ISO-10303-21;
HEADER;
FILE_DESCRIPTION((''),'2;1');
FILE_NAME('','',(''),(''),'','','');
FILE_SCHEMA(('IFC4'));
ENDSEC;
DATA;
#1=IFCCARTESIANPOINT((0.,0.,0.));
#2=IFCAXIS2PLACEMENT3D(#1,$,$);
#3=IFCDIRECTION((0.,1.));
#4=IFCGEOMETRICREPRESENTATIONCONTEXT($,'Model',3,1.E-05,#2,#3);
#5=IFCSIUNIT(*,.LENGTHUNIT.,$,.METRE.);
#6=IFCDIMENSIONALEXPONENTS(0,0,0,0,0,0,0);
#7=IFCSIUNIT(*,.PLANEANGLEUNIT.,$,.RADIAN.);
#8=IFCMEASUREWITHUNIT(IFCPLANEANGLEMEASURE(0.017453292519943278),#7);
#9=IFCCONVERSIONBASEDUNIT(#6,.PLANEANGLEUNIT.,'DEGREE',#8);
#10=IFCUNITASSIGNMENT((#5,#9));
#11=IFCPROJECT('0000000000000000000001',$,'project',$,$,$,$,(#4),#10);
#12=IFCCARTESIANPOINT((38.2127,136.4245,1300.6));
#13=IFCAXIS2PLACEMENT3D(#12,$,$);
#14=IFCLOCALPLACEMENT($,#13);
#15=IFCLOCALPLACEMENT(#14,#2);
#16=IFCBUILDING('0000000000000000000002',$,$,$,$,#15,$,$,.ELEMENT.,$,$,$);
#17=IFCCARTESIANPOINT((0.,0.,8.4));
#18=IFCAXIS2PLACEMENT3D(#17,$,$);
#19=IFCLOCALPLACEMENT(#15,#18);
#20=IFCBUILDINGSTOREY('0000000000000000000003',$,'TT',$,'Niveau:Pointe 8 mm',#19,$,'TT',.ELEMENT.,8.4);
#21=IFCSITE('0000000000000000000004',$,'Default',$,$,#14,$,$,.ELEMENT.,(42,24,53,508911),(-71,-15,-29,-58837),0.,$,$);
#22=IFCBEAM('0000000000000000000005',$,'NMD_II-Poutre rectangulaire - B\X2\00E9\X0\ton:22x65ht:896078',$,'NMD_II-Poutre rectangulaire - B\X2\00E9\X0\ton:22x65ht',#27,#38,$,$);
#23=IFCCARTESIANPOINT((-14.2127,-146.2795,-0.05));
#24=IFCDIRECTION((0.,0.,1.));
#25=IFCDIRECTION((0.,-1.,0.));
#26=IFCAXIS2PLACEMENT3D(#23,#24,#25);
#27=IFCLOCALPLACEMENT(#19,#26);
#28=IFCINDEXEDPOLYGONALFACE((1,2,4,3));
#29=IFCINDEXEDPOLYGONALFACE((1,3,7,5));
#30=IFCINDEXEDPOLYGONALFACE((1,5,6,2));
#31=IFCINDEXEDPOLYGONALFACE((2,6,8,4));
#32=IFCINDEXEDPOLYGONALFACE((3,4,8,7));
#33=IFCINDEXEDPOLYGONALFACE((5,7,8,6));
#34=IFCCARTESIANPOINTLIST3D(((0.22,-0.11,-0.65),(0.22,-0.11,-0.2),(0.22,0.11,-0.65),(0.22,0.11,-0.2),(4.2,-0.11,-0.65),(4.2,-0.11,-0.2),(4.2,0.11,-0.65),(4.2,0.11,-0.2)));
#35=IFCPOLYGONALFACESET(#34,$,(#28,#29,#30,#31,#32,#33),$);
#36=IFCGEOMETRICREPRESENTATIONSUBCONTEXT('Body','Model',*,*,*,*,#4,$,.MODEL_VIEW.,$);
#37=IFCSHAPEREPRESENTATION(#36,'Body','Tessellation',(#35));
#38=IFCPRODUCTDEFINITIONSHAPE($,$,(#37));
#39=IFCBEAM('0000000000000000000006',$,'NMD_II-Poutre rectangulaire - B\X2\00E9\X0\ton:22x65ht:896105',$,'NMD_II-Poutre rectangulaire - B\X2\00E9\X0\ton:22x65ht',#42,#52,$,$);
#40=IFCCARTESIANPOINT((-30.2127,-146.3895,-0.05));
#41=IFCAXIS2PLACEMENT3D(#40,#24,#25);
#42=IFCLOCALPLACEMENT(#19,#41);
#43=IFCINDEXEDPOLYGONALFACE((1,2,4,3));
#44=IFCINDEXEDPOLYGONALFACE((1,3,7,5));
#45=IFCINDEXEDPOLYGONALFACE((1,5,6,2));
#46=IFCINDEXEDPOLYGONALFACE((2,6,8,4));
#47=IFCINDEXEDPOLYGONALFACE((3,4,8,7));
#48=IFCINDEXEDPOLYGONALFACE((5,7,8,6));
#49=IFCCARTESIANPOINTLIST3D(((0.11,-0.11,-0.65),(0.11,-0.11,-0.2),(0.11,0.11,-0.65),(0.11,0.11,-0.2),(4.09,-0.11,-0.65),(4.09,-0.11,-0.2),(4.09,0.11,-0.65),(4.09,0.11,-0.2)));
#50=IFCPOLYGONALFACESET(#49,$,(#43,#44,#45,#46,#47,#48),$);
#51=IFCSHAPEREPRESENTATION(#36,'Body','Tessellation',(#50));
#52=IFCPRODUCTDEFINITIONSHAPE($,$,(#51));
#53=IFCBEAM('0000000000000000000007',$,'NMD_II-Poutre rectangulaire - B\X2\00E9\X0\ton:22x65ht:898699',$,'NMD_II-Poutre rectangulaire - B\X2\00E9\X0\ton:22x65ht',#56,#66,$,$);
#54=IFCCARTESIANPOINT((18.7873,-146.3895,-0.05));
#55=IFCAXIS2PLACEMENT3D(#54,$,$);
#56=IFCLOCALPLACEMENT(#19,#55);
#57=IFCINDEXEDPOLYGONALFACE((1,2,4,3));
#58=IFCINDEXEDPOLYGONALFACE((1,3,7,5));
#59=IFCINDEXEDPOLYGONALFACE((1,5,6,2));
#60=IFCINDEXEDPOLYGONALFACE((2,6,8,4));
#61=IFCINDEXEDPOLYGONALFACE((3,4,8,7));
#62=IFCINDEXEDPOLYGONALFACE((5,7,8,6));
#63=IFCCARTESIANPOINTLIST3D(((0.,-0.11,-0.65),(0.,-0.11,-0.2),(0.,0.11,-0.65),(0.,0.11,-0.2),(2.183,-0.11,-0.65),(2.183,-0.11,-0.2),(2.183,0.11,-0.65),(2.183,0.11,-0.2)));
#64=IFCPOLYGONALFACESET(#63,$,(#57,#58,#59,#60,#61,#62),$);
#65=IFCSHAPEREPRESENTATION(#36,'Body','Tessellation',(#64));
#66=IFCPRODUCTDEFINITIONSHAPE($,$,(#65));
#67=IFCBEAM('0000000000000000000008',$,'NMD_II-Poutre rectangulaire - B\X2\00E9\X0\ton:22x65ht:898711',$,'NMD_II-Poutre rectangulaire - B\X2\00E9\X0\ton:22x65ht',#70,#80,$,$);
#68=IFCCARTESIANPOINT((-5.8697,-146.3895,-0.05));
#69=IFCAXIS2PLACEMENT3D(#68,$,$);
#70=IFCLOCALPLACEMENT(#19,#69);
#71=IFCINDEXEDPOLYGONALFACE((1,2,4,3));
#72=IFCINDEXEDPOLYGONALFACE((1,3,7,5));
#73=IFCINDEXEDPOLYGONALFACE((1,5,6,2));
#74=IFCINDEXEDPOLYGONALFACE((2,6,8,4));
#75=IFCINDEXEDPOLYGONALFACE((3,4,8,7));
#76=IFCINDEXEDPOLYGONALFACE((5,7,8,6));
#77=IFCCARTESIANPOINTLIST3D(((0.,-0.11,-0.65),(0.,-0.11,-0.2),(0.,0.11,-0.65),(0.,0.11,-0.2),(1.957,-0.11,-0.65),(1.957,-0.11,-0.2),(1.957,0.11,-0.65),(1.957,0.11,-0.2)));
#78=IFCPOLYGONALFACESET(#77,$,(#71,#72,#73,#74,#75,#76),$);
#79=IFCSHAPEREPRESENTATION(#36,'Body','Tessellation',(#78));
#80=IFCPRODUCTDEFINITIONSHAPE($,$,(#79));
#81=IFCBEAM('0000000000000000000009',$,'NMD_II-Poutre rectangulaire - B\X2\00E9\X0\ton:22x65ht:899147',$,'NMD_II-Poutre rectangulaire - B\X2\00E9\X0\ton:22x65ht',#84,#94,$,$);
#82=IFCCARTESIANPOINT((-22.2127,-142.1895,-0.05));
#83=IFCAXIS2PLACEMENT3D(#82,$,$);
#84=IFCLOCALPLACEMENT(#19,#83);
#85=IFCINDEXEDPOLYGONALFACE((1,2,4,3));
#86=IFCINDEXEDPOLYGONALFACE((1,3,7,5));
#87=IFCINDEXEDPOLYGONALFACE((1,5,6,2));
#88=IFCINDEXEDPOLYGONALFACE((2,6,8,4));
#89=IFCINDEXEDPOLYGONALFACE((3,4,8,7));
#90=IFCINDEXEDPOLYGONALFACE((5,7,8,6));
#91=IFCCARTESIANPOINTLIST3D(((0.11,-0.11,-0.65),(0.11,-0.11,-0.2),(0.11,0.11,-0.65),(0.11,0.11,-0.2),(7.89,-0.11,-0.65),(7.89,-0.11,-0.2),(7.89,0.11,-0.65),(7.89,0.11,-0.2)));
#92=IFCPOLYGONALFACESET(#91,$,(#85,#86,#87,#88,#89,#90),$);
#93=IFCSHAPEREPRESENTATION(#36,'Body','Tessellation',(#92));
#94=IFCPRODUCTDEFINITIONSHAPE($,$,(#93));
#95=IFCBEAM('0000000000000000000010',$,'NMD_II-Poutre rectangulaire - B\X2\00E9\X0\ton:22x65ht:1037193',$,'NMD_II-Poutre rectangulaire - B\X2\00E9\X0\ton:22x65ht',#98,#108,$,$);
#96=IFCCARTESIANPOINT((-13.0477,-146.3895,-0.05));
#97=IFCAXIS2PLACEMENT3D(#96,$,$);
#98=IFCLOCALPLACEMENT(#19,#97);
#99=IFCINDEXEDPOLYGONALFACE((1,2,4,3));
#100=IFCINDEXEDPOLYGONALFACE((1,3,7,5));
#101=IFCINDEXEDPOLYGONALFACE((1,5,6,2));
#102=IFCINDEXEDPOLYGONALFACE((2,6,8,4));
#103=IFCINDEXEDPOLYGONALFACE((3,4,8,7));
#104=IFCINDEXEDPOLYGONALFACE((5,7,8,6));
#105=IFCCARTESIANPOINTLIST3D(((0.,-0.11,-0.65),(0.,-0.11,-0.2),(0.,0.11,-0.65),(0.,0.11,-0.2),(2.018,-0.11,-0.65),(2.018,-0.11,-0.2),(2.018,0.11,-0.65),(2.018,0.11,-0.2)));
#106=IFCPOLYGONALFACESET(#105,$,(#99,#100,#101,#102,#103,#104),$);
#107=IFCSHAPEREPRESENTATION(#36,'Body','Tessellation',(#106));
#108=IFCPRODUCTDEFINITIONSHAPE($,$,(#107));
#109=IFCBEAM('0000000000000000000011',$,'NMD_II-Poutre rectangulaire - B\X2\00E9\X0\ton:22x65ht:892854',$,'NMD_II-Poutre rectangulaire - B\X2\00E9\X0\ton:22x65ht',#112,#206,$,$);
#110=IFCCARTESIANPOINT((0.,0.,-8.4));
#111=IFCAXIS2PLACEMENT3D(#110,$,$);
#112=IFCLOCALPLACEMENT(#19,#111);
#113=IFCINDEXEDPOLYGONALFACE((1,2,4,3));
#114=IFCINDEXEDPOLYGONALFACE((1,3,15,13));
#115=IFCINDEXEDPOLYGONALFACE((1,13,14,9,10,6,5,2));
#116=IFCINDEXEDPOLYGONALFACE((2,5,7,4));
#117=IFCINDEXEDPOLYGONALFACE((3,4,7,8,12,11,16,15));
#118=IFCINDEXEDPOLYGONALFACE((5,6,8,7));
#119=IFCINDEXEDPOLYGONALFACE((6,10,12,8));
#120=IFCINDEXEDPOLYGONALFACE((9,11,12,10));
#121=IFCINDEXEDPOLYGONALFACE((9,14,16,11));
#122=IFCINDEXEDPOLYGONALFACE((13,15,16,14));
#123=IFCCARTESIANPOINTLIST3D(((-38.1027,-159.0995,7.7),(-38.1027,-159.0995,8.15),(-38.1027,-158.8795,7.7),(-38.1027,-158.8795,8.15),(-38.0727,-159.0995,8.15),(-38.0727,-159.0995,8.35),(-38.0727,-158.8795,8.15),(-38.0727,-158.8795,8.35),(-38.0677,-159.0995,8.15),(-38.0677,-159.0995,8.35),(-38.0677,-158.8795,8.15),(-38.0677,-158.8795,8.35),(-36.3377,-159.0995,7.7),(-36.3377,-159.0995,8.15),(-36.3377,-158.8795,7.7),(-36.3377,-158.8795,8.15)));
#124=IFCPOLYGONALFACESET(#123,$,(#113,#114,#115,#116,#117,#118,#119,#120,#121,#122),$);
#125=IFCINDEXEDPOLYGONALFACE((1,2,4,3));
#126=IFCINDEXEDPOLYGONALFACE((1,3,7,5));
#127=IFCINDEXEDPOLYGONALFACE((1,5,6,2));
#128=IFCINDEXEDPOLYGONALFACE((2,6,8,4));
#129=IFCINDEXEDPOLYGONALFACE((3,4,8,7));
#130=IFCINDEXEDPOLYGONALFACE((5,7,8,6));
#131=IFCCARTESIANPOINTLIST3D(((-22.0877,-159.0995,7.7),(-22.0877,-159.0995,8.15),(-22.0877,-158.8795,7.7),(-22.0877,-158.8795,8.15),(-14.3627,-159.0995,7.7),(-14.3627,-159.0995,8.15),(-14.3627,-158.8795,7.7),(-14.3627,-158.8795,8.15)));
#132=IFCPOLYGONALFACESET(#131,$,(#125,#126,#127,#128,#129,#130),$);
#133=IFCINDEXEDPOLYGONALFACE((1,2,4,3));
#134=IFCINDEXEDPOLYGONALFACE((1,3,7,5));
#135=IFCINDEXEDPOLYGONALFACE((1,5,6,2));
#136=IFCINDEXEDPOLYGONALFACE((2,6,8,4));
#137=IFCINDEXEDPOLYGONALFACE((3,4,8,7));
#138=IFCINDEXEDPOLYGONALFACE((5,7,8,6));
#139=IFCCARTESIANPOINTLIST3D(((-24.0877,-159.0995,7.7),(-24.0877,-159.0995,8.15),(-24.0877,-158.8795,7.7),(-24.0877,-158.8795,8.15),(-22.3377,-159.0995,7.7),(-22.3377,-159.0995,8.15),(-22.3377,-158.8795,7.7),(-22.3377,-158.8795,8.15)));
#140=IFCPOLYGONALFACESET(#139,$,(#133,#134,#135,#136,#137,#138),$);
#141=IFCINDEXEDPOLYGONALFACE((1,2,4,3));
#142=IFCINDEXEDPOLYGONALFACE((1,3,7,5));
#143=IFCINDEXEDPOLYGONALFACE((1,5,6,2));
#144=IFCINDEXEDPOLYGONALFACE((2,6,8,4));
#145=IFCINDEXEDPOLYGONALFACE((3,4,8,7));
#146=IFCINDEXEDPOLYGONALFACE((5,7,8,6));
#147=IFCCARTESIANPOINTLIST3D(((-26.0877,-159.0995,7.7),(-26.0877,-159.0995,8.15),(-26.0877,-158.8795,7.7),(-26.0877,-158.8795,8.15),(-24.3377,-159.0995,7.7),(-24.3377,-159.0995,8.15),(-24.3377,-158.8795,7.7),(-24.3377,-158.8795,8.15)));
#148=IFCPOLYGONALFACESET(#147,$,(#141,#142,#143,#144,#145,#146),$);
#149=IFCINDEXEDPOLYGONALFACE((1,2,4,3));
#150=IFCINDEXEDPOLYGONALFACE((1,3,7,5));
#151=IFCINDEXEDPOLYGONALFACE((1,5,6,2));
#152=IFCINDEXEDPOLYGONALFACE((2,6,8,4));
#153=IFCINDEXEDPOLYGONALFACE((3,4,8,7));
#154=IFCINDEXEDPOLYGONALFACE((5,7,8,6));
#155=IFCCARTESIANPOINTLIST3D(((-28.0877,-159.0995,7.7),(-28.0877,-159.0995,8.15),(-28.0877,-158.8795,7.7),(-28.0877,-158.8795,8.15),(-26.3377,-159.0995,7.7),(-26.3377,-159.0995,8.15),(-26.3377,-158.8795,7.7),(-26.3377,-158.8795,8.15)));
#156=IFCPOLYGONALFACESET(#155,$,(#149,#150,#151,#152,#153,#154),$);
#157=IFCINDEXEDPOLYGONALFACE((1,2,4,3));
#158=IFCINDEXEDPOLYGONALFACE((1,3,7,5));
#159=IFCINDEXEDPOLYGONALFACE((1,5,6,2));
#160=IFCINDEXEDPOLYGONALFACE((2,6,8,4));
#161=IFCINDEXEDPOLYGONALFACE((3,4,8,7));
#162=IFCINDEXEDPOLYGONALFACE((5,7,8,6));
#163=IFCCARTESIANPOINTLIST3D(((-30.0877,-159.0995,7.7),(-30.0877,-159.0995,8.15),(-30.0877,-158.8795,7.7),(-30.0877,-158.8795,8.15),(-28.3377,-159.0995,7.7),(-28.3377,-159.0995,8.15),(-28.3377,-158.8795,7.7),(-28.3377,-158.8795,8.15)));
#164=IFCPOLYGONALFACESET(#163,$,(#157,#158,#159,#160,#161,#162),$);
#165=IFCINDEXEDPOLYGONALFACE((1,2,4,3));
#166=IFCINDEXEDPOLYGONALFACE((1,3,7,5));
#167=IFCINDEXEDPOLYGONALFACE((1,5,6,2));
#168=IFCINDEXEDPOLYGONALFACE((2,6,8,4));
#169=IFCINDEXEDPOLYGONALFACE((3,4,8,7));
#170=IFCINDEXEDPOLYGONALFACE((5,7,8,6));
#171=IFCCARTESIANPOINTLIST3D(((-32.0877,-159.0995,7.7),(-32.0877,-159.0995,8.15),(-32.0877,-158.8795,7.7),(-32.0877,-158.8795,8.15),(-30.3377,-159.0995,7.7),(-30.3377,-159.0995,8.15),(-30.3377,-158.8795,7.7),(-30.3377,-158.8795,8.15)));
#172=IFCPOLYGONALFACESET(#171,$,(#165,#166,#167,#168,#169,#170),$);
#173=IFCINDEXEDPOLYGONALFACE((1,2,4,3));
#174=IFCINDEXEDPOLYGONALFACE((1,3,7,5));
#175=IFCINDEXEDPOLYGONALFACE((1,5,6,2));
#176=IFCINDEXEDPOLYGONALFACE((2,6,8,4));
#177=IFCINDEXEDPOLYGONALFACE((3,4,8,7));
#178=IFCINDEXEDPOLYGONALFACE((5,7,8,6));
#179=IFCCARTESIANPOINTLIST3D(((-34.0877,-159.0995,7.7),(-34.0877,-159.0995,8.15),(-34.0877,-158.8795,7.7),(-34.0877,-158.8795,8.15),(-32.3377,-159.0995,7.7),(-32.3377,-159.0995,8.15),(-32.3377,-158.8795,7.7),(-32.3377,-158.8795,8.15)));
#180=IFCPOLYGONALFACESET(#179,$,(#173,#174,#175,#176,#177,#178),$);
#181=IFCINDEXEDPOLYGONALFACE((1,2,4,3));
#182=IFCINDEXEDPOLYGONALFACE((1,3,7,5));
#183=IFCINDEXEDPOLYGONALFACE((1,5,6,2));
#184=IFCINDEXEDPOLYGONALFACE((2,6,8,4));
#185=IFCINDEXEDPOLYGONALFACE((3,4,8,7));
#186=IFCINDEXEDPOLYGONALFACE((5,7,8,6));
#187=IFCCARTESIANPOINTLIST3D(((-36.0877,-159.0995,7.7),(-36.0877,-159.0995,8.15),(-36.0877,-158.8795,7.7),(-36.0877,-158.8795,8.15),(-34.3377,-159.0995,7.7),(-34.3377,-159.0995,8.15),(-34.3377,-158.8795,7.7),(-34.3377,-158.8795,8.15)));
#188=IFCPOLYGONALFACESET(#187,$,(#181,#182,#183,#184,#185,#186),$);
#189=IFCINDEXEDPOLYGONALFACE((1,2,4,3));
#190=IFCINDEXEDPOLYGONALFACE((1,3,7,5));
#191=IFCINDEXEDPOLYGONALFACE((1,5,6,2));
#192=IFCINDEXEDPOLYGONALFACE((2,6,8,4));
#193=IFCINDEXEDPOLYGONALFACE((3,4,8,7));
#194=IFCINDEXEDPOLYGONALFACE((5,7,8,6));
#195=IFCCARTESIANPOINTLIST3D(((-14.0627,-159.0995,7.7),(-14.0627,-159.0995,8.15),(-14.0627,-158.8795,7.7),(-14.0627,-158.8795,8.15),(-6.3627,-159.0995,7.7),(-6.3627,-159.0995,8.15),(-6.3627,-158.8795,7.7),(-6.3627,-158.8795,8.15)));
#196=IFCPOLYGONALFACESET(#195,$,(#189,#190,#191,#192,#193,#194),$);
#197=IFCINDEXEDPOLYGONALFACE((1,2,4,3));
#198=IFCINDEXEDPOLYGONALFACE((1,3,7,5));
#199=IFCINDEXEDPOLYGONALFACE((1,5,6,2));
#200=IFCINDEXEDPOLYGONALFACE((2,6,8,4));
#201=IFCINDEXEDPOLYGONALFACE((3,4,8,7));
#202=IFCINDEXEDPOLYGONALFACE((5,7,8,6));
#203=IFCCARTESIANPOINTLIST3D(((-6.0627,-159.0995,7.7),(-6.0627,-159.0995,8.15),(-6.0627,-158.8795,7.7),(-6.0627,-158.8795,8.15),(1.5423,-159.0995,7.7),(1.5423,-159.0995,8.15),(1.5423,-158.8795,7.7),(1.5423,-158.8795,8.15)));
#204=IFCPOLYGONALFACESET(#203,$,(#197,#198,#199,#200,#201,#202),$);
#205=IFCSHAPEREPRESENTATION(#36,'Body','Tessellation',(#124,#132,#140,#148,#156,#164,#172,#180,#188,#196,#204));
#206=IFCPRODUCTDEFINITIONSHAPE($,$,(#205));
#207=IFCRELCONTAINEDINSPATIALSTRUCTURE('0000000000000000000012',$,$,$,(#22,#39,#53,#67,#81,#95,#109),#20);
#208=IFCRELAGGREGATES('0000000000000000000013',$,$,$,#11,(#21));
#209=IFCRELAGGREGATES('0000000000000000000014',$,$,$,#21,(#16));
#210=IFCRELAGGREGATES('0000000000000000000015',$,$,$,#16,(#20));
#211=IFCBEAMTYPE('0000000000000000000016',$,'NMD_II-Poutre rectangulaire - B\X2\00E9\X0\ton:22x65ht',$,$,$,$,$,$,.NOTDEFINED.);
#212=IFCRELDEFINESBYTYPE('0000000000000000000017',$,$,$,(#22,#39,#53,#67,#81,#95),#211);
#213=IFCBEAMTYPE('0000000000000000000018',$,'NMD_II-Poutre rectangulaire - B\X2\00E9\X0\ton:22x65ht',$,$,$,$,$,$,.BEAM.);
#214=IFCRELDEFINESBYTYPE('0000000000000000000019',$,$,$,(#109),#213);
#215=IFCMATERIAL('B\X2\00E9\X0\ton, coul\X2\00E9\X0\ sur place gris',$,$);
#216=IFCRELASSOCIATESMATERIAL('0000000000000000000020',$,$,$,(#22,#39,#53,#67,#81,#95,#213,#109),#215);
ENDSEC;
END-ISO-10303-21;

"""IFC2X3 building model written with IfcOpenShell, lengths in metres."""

from ifc_helpers import new_model, entity, si_unit, converted_unit, direction, frame, frame_2d, origin, place, context, subcontext, project, spatial, polyline, rectangle, outline, extrude, source, transform, mapped, material, type_object, type_shapes, element, save


model = new_model("IFC2X3")

# Units and contexts
model_context = context("Model", 3, precision=1e-05, world=origin(), true_north=direction((0.0, 1.0)))
body_context = subcontext(model_context, "Body", "Model", "MODEL_VIEW")
ifc_project = project(units=[si_unit("LENGTHUNIT", "METRE"), converted_unit("PLANEANGLEUNIT", "DEGREE", entity("IfcPlaneAngleMeasure", 0.017453292519943278), si_unit("PLANEANGLEUNIT", "RADIAN"), dimensions=[0, 0, 0, 0, 0, 0, 0])], contexts=[model_context])

# Site, building, storey
site_placement = place(None, frame((38.2127, 136.4245, 1300.6)))
site = spatial("IfcSite", under=ifc_project, at=site_placement, Name="Default", CompositionType="ELEMENT", RefLatitude=(42, 24, 53, 508911), RefLongitude=(-71, -15, -29, -58837), RefElevation=0.0)
building_placement = place(site_placement, origin())
building = spatial("IfcBuilding", under=site, at=building_placement, CompositionType="ELEMENT")
storey_placement = place(building_placement, frame((0.0, 0.0, 8.4)))
storey = spatial("IfcBuildingStorey", under=building, at=storey_placement, Name="TT", ObjectType="Niveau:Pointe 8 mm", LongName="TT", CompositionType="ELEMENT", Elevation=8.4)

# Beams
ifc_material_1 = material(Name="Béton, coulé sur place gris")
beam_type_1 = type_object("IfcBeamType", Name="NMD_II-Poutre rectangulaire - Béton:22x65ht", PredefinedType="NOTDEFINED")
beam_1_placement = place(storey_placement, frame((-14.2127, -146.2795, -0.05), z_axis=(0.0, 0.0, 1.0), x_axis=(0.0, -1.0, 0.0)))
element("IfcBeam", 1, at=beam_1_placement, inside=storey, type_object=beam_type_1, material=ifc_material_1, Name="NMD_II-Poutre rectangulaire - Béton:22x65ht:896078", ObjectType="NMD_II-Poutre rectangulaire - Béton:22x65ht", context=body_context, shape_type="SweptSolid", body=[
    extrude(rectangle(XDim=0.45, YDim=0.22, at=frame_2d((0.0, 0.0), x_axis=(1.0, 0.0))), frame((0.22, 0.0, -0.425), z_axis=(1.0, 0.0, 0.0), x_axis=(0.0, 0.0, -1.0)), (0.0, 0.0, 1.0), 3.98),
])
beam_2_placement = place(storey_placement, frame((-30.2127, -146.3895, -0.05), z_axis=(0.0, 0.0, 1.0), x_axis=(0.0, -1.0, 0.0)))
element("IfcBeam", 2, at=beam_2_placement, inside=storey, type_object=beam_type_1, material=ifc_material_1, Name="NMD_II-Poutre rectangulaire - Béton:22x65ht:896105", ObjectType="NMD_II-Poutre rectangulaire - Béton:22x65ht", context=body_context, shape_type="SweptSolid", body=[
    extrude(rectangle(XDim=0.45, YDim=0.22, at=frame_2d((0.0, 0.0), x_axis=(1.0, 0.0))), frame((0.11, 0.0, -0.425), z_axis=(1.0, 0.0, 0.0), x_axis=(0.0, 0.0, -1.0)), (0.0, 0.0, 1.0), 3.98),
])
beam_3_placement = place(storey_placement, frame((18.7873, -146.3895, -0.05)))
element("IfcBeam", 3, at=beam_3_placement, inside=storey, type_object=beam_type_1, material=ifc_material_1, Name="NMD_II-Poutre rectangulaire - Béton:22x65ht:898699", ObjectType="NMD_II-Poutre rectangulaire - Béton:22x65ht", context=body_context, shape_type="SweptSolid", body=[
    extrude(rectangle(XDim=0.45, YDim=0.22, at=frame_2d((0.0, 0.0), x_axis=(1.0, 0.0))), frame((0.0, 0.0, -0.425), z_axis=(1.0, 0.0, 0.0), x_axis=(0.0, 0.0, -1.0)), (0.0, 0.0, 1.0), 2.183),
])
beam_4_placement = place(storey_placement, frame((-5.8697, -146.3895, -0.05)))
element("IfcBeam", 4, at=beam_4_placement, inside=storey, type_object=beam_type_1, material=ifc_material_1, Name="NMD_II-Poutre rectangulaire - Béton:22x65ht:898711", ObjectType="NMD_II-Poutre rectangulaire - Béton:22x65ht", context=body_context, shape_type="SweptSolid", body=[
    extrude(rectangle(XDim=0.45, YDim=0.22, at=frame_2d((0.0, 0.0), x_axis=(1.0, 0.0))), frame((0.0, 0.0, -0.425), z_axis=(1.0, 0.0, 0.0), x_axis=(0.0, 0.0, -1.0)), (0.0, 0.0, 1.0), 1.957),
])
beam_5_placement = place(storey_placement, frame((-22.2127, -142.1895, -0.05)))
element("IfcBeam", 5, at=beam_5_placement, inside=storey, type_object=beam_type_1, material=ifc_material_1, Name="NMD_II-Poutre rectangulaire - Béton:22x65ht:899147", ObjectType="NMD_II-Poutre rectangulaire - Béton:22x65ht", context=body_context, shape_type="SweptSolid", body=[
    extrude(rectangle(XDim=0.45, YDim=0.22, at=frame_2d((0.0, 0.0), x_axis=(1.0, 0.0))), frame((0.11, 0.0, -0.425), z_axis=(1.0, 0.0, 0.0), x_axis=(0.0, 0.0, -1.0)), (0.0, 0.0, 1.0), 7.78),
])
beam_6_placement = place(storey_placement, frame((-13.0477, -146.3895, -0.05)))
element("IfcBeam", 6, at=beam_6_placement, inside=storey, type_object=beam_type_1, material=ifc_material_1, Name="NMD_II-Poutre rectangulaire - Béton:22x65ht:1037193", ObjectType="NMD_II-Poutre rectangulaire - Béton:22x65ht", context=body_context, shape_type="SweptSolid", body=[
    extrude(rectangle(XDim=0.45, YDim=0.22, at=frame_2d((0.0, 0.0), x_axis=(1.0, 0.0))), frame((0.0, 0.0, -0.425), z_axis=(1.0, 0.0, 0.0), x_axis=(0.0, 0.0, -1.0)), (0.0, 0.0, 1.0), 2.018),
])
beam_type_2 = type_object("IfcBeamType", Name="NMD_II-Poutre rectangulaire - Béton:22x65ht", PredefinedType="BEAM", material=ifc_material_1)
shared_shape_1 = source(origin(), body_context, "Body", "SweptSolid", [
    extrude(outline(polyline([(-0.3875, -0.4575), (0.0625, -0.4575), (0.0625, -0.4275), (0.2625, -0.4275), (0.2625, -0.4225), (0.0625, -0.4225), (0.0625, 1.3075), (-0.3875, 1.3075), (-0.3875, -0.4575)])), frame((-37.6452, -159.0995, 8.0875), z_axis=(0.0, 1.0, 0.0), x_axis=(0.0, 0.0, 1.0)), (0.0, 0.0, 1.0), 0.22),
    extrude(rectangle(XDim=0.45, YDim=0.22, at=frame_2d((0.0, 0.0), x_axis=(1.0, 0.0))), frame((-22.0877, -158.9895, 7.925), z_axis=(1.0, 0.0, 0.0), x_axis=(0.0, 0.0, 1.0)), (0.0, 0.0, 1.0), 7.725),
    extrude(rectangle(XDim=0.45, YDim=0.22, at=frame_2d((0.0, 0.0), x_axis=(1.0, 0.0))), frame((-24.0877, -158.9895, 7.925), z_axis=(1.0, 0.0, 0.0), x_axis=(0.0, 0.0, 1.0)), (0.0, 0.0, 1.0), 1.75),
    extrude(rectangle(XDim=0.45, YDim=0.22, at=frame_2d((0.0, 0.0), x_axis=(1.0, 0.0))), frame((-26.0877, -158.9895, 7.925), z_axis=(1.0, 0.0, 0.0), x_axis=(0.0, 0.0, 1.0)), (0.0, 0.0, 1.0), 1.75),
    extrude(rectangle(XDim=0.45, YDim=0.22, at=frame_2d((0.0, 0.0), x_axis=(1.0, 0.0))), frame((-28.0877, -158.9895, 7.925), z_axis=(1.0, 0.0, 0.0), x_axis=(0.0, 0.0, 1.0)), (0.0, 0.0, 1.0), 1.75),
    extrude(rectangle(XDim=0.45, YDim=0.22, at=frame_2d((0.0, 0.0), x_axis=(1.0, 0.0))), frame((-30.0877, -158.9895, 7.925), z_axis=(1.0, 0.0, 0.0), x_axis=(0.0, 0.0, 1.0)), (0.0, 0.0, 1.0), 1.75),
    extrude(rectangle(XDim=0.45, YDim=0.22, at=frame_2d((0.0, 0.0), x_axis=(1.0, 0.0))), frame((-32.0877, -158.9895, 7.925), z_axis=(1.0, 0.0, 0.0), x_axis=(0.0, 0.0, 1.0)), (0.0, 0.0, 1.0), 1.75),
    extrude(rectangle(XDim=0.45, YDim=0.22, at=frame_2d((0.0, 0.0), x_axis=(1.0, 0.0))), frame((-34.0877, -158.9895, 7.925), z_axis=(1.0, 0.0, 0.0), x_axis=(0.0, 0.0, 1.0)), (0.0, 0.0, 1.0), 1.75),
    extrude(rectangle(XDim=0.45, YDim=0.22, at=frame_2d((0.0, 0.0), x_axis=(1.0, 0.0))), frame((-36.0877, -158.9895, 7.925), z_axis=(1.0, 0.0, 0.0), x_axis=(0.0, 0.0, 1.0)), (0.0, 0.0, 1.0), 1.75),
    extrude(rectangle(XDim=0.45, YDim=0.22, at=frame_2d((0.0, 0.0), x_axis=(1.0, 0.0))), frame((-14.0627, -158.9895, 7.925), z_axis=(1.0, 0.0, 0.0), x_axis=(0.0, 0.0, 1.0)), (0.0, 0.0, 1.0), 7.7),
    extrude(rectangle(XDim=0.45, YDim=7.605, at=frame_2d((0.0, 0.0), x_axis=(1.0, 0.0))), frame((-2.2602, -159.0995, 7.925), z_axis=(0.0, 1.0, 0.0), x_axis=(0.0, 0.0, 1.0)), (0.0, 0.0, 1.0), 0.22),
])
type_shapes(beam_type_2, [shared_shape_1])
beam_7_placement = place(storey_placement, frame((0.0, 0.0, -8.4)))
element("IfcBeam", 7, at=beam_7_placement, inside=storey, type_object=beam_type_2, material=ifc_material_1, Name="NMD_II-Poutre rectangulaire - Béton:22x65ht:892854", ObjectType="NMD_II-Poutre rectangulaire - Béton:22x65ht", context=body_context, shape_type="MappedRepresentation", body=[
    mapped(shared_shape_1, transform((0.0, 0.0, 0.0), scale=1.0)),
])

save(model, "model.ifc")
